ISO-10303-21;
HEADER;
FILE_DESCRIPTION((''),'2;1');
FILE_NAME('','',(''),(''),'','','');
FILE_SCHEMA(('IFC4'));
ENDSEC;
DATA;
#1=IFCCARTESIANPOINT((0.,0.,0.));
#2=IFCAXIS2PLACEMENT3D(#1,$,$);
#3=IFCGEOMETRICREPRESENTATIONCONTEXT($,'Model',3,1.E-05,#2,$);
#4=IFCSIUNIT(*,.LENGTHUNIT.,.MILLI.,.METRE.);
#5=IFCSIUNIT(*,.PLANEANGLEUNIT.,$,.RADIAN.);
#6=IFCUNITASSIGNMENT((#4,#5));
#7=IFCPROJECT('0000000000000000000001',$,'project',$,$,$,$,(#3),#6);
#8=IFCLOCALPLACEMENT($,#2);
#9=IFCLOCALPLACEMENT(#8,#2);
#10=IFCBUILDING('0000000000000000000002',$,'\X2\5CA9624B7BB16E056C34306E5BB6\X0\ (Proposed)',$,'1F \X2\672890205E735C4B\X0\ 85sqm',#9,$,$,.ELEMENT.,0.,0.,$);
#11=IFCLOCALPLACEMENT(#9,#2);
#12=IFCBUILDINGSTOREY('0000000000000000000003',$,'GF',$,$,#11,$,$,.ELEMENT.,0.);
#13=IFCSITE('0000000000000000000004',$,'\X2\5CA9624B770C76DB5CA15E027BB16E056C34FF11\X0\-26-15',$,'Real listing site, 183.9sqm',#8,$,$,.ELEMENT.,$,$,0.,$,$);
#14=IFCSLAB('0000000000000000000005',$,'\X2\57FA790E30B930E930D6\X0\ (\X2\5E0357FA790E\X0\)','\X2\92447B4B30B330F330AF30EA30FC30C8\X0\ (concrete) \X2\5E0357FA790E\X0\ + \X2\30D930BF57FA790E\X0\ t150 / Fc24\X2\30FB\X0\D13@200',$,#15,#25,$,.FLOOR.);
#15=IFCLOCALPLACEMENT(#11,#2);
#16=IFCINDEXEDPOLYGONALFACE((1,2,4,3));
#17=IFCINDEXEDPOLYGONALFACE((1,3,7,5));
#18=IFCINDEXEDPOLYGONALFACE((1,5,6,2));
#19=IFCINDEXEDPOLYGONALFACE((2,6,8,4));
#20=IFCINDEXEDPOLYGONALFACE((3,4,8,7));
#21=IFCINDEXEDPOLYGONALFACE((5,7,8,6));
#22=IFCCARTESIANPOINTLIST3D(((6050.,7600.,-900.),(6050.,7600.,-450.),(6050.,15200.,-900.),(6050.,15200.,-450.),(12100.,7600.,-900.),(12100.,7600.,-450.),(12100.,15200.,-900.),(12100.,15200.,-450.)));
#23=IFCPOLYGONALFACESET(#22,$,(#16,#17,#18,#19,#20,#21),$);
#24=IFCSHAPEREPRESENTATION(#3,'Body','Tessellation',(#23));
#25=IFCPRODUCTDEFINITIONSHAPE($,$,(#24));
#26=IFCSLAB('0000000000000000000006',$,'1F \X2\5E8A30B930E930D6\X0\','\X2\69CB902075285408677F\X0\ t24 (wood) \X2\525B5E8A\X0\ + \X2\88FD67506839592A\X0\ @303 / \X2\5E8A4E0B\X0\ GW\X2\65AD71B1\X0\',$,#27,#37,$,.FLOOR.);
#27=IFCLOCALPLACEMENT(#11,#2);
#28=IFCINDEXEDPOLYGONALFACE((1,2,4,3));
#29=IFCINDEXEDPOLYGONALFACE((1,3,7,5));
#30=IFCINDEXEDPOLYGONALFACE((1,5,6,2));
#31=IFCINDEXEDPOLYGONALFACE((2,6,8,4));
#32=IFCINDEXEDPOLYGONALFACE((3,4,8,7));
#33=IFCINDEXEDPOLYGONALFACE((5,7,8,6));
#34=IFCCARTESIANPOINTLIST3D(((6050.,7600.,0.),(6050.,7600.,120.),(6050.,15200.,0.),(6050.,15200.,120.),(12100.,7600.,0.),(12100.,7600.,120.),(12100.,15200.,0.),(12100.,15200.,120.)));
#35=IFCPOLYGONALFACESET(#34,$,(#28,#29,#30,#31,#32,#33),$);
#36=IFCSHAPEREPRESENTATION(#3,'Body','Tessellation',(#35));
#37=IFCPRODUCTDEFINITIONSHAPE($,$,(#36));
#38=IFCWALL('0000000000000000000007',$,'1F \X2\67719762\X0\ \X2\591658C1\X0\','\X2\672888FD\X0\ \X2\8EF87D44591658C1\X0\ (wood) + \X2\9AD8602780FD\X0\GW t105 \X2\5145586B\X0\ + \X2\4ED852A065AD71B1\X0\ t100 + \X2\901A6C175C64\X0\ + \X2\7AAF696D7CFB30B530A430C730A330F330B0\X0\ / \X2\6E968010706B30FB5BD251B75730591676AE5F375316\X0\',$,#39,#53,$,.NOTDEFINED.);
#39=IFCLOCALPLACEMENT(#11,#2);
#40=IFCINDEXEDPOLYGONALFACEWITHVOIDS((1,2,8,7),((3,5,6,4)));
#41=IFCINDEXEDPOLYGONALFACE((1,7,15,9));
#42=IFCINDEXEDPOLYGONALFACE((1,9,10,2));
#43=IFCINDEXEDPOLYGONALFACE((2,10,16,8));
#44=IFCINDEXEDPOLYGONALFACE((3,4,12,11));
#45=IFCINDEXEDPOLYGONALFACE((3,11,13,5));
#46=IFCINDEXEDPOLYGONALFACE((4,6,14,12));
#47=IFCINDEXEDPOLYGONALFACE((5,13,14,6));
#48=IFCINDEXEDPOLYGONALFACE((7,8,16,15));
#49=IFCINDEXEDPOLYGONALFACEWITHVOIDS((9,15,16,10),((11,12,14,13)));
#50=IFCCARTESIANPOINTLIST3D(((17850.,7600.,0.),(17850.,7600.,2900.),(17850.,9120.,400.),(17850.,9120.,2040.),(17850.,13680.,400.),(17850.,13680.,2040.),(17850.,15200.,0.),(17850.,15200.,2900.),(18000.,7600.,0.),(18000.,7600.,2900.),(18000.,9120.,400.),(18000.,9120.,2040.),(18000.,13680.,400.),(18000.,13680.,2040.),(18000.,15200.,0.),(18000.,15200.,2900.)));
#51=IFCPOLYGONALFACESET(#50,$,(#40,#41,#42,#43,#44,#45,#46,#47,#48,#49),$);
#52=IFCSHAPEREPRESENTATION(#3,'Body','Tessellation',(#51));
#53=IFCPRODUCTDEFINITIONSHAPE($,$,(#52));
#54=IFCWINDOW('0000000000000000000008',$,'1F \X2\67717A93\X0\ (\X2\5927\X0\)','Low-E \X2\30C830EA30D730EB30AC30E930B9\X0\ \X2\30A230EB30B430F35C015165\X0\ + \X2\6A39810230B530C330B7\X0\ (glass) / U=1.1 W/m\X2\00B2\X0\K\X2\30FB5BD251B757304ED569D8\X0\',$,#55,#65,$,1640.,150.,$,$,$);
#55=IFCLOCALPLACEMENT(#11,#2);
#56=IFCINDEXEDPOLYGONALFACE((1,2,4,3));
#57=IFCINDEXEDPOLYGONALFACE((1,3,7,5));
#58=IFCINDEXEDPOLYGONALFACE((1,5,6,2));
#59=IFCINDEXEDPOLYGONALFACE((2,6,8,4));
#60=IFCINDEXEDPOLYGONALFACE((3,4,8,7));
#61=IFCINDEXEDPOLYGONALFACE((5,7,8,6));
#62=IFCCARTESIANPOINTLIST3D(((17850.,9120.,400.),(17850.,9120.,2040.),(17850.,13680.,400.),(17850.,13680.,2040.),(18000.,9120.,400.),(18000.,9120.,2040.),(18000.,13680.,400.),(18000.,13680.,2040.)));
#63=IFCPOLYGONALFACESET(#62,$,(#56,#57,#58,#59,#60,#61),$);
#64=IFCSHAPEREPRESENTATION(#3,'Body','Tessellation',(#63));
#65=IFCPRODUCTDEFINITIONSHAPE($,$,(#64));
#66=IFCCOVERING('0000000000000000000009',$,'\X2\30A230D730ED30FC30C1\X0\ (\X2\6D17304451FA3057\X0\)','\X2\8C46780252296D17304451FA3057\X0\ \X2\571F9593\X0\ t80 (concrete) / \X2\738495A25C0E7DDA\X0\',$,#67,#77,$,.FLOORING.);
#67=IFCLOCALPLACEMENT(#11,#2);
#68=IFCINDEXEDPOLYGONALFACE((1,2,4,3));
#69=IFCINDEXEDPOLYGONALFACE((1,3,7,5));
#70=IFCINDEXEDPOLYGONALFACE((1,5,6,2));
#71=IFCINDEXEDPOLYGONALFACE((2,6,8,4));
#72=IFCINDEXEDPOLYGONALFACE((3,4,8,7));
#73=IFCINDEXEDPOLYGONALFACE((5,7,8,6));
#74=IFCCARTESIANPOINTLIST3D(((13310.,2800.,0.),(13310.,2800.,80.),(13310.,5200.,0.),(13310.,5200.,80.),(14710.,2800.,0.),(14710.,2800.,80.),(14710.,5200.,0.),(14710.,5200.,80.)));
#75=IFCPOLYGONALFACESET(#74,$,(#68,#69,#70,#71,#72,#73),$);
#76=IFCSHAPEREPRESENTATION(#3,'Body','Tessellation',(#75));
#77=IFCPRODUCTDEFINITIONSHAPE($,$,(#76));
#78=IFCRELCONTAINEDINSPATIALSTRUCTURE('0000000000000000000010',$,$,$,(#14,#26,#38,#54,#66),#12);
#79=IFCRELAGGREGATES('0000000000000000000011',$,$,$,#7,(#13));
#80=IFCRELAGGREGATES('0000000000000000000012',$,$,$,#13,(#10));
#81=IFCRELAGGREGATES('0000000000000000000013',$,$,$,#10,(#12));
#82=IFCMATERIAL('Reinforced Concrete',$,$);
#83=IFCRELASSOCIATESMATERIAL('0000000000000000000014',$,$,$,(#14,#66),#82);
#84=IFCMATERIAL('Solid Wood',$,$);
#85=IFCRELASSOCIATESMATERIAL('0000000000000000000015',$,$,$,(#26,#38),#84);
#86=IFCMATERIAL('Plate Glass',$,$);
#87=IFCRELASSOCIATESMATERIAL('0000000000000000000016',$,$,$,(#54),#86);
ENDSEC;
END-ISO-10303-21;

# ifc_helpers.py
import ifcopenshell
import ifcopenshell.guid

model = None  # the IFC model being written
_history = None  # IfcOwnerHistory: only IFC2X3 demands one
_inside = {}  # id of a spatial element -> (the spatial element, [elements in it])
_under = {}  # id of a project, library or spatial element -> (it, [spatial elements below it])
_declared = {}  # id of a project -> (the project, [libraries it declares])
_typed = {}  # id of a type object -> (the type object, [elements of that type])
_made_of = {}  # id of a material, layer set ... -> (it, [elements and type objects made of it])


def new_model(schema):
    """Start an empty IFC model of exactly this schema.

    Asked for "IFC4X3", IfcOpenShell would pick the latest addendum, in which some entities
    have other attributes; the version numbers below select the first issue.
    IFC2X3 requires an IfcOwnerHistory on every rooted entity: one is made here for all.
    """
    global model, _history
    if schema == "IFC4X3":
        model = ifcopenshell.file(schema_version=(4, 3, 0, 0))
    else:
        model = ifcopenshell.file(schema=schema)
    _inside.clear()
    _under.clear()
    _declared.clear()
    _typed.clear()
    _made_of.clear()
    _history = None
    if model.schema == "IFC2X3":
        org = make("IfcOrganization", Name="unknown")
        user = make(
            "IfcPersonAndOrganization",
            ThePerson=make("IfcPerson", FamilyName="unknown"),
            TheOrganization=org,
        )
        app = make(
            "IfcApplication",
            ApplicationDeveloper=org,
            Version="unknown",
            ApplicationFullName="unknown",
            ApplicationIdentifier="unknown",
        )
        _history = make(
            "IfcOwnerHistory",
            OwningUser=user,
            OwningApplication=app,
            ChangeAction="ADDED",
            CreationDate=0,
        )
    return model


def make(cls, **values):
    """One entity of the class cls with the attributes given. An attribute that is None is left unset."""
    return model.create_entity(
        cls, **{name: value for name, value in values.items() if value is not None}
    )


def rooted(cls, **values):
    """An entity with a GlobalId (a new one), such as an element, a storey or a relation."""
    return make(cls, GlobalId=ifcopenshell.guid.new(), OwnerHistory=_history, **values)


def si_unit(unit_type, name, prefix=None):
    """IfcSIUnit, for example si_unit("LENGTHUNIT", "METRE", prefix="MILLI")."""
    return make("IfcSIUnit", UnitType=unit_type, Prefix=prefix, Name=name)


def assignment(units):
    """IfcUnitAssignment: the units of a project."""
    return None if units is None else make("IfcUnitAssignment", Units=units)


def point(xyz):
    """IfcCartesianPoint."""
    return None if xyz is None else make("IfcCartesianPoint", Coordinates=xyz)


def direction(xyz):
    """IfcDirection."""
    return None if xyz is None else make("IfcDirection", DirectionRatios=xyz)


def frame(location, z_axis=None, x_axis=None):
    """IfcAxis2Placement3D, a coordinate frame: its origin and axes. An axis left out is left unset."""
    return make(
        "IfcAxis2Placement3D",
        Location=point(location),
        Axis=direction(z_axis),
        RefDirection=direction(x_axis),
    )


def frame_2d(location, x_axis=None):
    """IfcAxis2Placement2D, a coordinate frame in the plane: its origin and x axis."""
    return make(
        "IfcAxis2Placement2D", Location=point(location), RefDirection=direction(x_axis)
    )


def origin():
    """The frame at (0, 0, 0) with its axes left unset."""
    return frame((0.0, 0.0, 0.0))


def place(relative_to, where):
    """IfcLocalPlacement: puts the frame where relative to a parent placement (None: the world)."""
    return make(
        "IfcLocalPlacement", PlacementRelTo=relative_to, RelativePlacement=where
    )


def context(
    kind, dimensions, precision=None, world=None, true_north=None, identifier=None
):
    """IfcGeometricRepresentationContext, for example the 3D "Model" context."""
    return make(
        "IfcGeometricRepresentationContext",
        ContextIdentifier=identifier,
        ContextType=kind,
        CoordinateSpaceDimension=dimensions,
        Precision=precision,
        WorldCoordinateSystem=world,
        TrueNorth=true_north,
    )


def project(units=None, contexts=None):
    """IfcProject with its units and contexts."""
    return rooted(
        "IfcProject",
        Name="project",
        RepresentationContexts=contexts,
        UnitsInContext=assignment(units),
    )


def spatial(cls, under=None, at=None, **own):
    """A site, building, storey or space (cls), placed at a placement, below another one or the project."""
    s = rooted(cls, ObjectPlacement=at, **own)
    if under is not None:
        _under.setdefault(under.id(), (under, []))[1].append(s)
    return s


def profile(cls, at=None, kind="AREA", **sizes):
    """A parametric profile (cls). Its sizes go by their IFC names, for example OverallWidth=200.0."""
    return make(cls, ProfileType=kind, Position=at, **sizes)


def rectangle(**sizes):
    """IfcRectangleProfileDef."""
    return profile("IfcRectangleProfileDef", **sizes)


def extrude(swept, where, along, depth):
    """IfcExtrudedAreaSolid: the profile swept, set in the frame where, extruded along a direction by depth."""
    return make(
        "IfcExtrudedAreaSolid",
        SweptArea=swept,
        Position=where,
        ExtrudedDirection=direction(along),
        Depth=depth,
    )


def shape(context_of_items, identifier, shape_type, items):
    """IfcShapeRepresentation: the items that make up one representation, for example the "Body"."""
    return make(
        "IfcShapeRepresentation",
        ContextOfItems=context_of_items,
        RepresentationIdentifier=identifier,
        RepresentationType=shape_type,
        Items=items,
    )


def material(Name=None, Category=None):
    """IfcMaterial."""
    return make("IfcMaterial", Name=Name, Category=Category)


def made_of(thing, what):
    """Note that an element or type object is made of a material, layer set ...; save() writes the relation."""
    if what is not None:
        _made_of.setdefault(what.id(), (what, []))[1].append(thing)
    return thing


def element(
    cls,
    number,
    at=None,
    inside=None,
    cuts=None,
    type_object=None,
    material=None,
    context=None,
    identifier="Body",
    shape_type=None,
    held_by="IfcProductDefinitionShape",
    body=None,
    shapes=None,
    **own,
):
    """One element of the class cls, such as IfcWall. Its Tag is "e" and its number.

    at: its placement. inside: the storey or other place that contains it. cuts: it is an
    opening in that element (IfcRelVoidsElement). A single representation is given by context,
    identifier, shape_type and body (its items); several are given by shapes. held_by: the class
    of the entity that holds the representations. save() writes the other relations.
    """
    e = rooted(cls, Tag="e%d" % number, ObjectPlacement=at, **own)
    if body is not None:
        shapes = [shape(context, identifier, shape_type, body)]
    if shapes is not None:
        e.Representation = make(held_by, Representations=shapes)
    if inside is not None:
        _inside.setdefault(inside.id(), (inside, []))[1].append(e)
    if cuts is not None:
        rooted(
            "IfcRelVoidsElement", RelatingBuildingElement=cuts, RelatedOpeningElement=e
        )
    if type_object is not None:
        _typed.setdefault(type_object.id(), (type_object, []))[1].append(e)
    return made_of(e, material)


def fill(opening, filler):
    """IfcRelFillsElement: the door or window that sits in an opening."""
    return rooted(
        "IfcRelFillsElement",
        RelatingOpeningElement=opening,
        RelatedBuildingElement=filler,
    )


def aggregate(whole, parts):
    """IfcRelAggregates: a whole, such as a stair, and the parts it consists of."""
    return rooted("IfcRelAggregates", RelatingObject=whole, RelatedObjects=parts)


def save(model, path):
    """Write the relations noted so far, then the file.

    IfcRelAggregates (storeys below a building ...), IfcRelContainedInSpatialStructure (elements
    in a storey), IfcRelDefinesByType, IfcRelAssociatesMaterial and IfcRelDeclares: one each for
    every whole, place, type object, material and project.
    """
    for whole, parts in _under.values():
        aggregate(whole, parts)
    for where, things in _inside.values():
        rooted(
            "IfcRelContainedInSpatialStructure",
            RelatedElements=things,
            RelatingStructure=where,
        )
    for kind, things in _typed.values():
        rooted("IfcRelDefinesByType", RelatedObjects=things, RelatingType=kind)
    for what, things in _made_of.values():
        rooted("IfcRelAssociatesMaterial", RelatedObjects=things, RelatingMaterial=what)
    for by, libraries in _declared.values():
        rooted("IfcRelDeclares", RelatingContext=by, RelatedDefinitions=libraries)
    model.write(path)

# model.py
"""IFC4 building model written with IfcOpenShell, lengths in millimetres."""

from ifc_helpers import new_model, si_unit, frame, frame_2d, origin, place, context, project, spatial, rectangle, extrude, material, element, fill, save


model = new_model("IFC4")

# Units and contexts
model_context = context("Model", 3, precision=1e-05, world=origin())
ifc_project = project(units=[si_unit("LENGTHUNIT", "METRE", prefix="MILLI"), si_unit("PLANEANGLEUNIT", "RADIAN")], contexts=[model_context])

# Site, building, storey
site_placement = place(None, origin())
site = spatial("IfcSite", under=ifc_project, at=site_placement, Name="岩手県盛岡市箱清水１-26-15", ObjectType="Real listing site, 183.9sqm", CompositionType="ELEMENT", RefElevation=0.0)
building_placement = place(site_placement, origin())
building = spatial("IfcBuilding", under=site, at=building_placement, Name="岩手箱清水の家 (Proposed)", ObjectType="1F 木造平屋 85sqm", CompositionType="ELEMENT", ElevationOfRefHeight=0.0, ElevationOfTerrain=0.0)
storey_placement = place(building_placement, origin())
storey = spatial("IfcBuildingStorey", under=building, at=storey_placement, Name="GF", CompositionType="ELEMENT", Elevation=0.0)

# Shared definitions
ifc_material_1 = material(Name="Solid Wood")

# Slabs
ifc_material_2 = material(Name="Reinforced Concrete")
slab_1_placement = place(storey_placement, frame((3025.0, 3800.0, -450.0)))
element("IfcSlab", 1, at=slab_1_placement, inside=storey, material=ifc_material_2, Name="基礎スラブ (布基礎)", Description="鉄筋コンクリート (concrete) 布基礎 + ベタ基礎 t150 / Fc24・D13@200", PredefinedType="FLOOR", context=model_context, shape_type="SweptSolid", body=[
    extrude(rectangle(XDim=6050.0, YDim=7600.0, at=frame_2d((3025.0, 3800.0))), frame((3025.0, 3800.0, -450.0)), (0.0, 0.0, 1.0), 450.0),
])
slab_2_placement = place(storey_placement, frame((3025.0, 3800.0, 0.0)))
element("IfcSlab", 2, at=slab_2_placement, inside=storey, material=ifc_material_1, Name="1F 床スラブ", Description="構造用合板 t24 (wood) 剛床 + 製材根太 @303 / 床下 GW断熱", PredefinedType="FLOOR", context=model_context, shape_type="SweptSolid", body=[
    extrude(rectangle(XDim=6050.0, YDim=7600.0, at=frame_2d((3025.0, 3800.0))), frame((3025.0, 3800.0, 0.0)), (0.0, 0.0, 1.0), 120.0),
])

# Shared definitions
ifc_material_3 = material(Name="Plate Glass")

# Wall, opening, window
wall_1_placement = place(storey_placement, frame((8925.0, 3800.0, 0.0)))
wall_1 = element("IfcWall", 3, at=wall_1_placement, inside=storey, material=ifc_material_1, Name="1F 東面 外壁", Description="木製 軸組外壁 (wood) + 高性能GW t105 充填 + 付加断熱 t100 + 通気層 + 窯業系サイディング / 準耐火・寒冷地外皮強化", PredefinedType="NOTDEFINED", context=model_context, shape_type="SweptSolid", body=[
    extrude(rectangle(XDim=150.0, YDim=7600.0, at=frame_2d((75.0, 3800.0))), frame((8925.0, 3800.0, 0.0)), (0.0, 0.0, 1.0), 2900.0),
])
opening_1_placement = place(storey_placement, frame((8925.0, 4560.0, 200.0)))
opening_1 = element("IfcOpeningElement", 4, at=opening_1_placement, cuts=wall_1, PredefinedType="NOTDEFINED", context=model_context, shape_type="SweptSolid", body=[
    extrude(rectangle(XDim=150.0, YDim=4560.0, at=frame_2d((75.0, 2280.0))), frame((8925.0, 4560.0, 200.0)), (0.0, 0.0, 1.0), 1640.0),
])
window_1_placement = place(storey_placement, frame((8925.0, 4560.0, 200.0)))
window_1 = element("IfcWindow", 5, at=window_1_placement, inside=storey, material=ifc_material_3, Name="1F 東窓 (大)", Description="Low-E トリプルガラス アルゴン封入 + 樹脂サッシ (glass) / U=1.1 W/m²K・寒冷地仕様", OverallHeight=1640.0, OverallWidth=150.0, context=model_context, shape_type="SweptSolid", body=[
    extrude(rectangle(XDim=150.0, YDim=4560.0, at=frame_2d((75.0, 2280.0))), frame((8925.0, 4560.0, 200.0)), (0.0, 0.0, 1.0), 1640.0),
])
fill(opening_1, window_1)

# Covering
covering_1_placement = place(storey_placement, frame((6655.0, 1400.0, 0.0)))
element("IfcCovering", 6, at=covering_1_placement, inside=storey, material=ifc_material_2, Name="アプローチ (洗い出し)", Description="豆砂利洗い出し 土間 t80 (concrete) / 玄関導線", PredefinedType="FLOORING", context=model_context, shape_type="SweptSolid", body=[
    extrude(rectangle(XDim=1400.0, YDim=2400.0, at=frame_2d((700.0, 1200.0))), frame((6655.0, 1400.0, 0.0)), (0.0, 0.0, 1.0), 80.0),
])

save(model, "model.ifc")
